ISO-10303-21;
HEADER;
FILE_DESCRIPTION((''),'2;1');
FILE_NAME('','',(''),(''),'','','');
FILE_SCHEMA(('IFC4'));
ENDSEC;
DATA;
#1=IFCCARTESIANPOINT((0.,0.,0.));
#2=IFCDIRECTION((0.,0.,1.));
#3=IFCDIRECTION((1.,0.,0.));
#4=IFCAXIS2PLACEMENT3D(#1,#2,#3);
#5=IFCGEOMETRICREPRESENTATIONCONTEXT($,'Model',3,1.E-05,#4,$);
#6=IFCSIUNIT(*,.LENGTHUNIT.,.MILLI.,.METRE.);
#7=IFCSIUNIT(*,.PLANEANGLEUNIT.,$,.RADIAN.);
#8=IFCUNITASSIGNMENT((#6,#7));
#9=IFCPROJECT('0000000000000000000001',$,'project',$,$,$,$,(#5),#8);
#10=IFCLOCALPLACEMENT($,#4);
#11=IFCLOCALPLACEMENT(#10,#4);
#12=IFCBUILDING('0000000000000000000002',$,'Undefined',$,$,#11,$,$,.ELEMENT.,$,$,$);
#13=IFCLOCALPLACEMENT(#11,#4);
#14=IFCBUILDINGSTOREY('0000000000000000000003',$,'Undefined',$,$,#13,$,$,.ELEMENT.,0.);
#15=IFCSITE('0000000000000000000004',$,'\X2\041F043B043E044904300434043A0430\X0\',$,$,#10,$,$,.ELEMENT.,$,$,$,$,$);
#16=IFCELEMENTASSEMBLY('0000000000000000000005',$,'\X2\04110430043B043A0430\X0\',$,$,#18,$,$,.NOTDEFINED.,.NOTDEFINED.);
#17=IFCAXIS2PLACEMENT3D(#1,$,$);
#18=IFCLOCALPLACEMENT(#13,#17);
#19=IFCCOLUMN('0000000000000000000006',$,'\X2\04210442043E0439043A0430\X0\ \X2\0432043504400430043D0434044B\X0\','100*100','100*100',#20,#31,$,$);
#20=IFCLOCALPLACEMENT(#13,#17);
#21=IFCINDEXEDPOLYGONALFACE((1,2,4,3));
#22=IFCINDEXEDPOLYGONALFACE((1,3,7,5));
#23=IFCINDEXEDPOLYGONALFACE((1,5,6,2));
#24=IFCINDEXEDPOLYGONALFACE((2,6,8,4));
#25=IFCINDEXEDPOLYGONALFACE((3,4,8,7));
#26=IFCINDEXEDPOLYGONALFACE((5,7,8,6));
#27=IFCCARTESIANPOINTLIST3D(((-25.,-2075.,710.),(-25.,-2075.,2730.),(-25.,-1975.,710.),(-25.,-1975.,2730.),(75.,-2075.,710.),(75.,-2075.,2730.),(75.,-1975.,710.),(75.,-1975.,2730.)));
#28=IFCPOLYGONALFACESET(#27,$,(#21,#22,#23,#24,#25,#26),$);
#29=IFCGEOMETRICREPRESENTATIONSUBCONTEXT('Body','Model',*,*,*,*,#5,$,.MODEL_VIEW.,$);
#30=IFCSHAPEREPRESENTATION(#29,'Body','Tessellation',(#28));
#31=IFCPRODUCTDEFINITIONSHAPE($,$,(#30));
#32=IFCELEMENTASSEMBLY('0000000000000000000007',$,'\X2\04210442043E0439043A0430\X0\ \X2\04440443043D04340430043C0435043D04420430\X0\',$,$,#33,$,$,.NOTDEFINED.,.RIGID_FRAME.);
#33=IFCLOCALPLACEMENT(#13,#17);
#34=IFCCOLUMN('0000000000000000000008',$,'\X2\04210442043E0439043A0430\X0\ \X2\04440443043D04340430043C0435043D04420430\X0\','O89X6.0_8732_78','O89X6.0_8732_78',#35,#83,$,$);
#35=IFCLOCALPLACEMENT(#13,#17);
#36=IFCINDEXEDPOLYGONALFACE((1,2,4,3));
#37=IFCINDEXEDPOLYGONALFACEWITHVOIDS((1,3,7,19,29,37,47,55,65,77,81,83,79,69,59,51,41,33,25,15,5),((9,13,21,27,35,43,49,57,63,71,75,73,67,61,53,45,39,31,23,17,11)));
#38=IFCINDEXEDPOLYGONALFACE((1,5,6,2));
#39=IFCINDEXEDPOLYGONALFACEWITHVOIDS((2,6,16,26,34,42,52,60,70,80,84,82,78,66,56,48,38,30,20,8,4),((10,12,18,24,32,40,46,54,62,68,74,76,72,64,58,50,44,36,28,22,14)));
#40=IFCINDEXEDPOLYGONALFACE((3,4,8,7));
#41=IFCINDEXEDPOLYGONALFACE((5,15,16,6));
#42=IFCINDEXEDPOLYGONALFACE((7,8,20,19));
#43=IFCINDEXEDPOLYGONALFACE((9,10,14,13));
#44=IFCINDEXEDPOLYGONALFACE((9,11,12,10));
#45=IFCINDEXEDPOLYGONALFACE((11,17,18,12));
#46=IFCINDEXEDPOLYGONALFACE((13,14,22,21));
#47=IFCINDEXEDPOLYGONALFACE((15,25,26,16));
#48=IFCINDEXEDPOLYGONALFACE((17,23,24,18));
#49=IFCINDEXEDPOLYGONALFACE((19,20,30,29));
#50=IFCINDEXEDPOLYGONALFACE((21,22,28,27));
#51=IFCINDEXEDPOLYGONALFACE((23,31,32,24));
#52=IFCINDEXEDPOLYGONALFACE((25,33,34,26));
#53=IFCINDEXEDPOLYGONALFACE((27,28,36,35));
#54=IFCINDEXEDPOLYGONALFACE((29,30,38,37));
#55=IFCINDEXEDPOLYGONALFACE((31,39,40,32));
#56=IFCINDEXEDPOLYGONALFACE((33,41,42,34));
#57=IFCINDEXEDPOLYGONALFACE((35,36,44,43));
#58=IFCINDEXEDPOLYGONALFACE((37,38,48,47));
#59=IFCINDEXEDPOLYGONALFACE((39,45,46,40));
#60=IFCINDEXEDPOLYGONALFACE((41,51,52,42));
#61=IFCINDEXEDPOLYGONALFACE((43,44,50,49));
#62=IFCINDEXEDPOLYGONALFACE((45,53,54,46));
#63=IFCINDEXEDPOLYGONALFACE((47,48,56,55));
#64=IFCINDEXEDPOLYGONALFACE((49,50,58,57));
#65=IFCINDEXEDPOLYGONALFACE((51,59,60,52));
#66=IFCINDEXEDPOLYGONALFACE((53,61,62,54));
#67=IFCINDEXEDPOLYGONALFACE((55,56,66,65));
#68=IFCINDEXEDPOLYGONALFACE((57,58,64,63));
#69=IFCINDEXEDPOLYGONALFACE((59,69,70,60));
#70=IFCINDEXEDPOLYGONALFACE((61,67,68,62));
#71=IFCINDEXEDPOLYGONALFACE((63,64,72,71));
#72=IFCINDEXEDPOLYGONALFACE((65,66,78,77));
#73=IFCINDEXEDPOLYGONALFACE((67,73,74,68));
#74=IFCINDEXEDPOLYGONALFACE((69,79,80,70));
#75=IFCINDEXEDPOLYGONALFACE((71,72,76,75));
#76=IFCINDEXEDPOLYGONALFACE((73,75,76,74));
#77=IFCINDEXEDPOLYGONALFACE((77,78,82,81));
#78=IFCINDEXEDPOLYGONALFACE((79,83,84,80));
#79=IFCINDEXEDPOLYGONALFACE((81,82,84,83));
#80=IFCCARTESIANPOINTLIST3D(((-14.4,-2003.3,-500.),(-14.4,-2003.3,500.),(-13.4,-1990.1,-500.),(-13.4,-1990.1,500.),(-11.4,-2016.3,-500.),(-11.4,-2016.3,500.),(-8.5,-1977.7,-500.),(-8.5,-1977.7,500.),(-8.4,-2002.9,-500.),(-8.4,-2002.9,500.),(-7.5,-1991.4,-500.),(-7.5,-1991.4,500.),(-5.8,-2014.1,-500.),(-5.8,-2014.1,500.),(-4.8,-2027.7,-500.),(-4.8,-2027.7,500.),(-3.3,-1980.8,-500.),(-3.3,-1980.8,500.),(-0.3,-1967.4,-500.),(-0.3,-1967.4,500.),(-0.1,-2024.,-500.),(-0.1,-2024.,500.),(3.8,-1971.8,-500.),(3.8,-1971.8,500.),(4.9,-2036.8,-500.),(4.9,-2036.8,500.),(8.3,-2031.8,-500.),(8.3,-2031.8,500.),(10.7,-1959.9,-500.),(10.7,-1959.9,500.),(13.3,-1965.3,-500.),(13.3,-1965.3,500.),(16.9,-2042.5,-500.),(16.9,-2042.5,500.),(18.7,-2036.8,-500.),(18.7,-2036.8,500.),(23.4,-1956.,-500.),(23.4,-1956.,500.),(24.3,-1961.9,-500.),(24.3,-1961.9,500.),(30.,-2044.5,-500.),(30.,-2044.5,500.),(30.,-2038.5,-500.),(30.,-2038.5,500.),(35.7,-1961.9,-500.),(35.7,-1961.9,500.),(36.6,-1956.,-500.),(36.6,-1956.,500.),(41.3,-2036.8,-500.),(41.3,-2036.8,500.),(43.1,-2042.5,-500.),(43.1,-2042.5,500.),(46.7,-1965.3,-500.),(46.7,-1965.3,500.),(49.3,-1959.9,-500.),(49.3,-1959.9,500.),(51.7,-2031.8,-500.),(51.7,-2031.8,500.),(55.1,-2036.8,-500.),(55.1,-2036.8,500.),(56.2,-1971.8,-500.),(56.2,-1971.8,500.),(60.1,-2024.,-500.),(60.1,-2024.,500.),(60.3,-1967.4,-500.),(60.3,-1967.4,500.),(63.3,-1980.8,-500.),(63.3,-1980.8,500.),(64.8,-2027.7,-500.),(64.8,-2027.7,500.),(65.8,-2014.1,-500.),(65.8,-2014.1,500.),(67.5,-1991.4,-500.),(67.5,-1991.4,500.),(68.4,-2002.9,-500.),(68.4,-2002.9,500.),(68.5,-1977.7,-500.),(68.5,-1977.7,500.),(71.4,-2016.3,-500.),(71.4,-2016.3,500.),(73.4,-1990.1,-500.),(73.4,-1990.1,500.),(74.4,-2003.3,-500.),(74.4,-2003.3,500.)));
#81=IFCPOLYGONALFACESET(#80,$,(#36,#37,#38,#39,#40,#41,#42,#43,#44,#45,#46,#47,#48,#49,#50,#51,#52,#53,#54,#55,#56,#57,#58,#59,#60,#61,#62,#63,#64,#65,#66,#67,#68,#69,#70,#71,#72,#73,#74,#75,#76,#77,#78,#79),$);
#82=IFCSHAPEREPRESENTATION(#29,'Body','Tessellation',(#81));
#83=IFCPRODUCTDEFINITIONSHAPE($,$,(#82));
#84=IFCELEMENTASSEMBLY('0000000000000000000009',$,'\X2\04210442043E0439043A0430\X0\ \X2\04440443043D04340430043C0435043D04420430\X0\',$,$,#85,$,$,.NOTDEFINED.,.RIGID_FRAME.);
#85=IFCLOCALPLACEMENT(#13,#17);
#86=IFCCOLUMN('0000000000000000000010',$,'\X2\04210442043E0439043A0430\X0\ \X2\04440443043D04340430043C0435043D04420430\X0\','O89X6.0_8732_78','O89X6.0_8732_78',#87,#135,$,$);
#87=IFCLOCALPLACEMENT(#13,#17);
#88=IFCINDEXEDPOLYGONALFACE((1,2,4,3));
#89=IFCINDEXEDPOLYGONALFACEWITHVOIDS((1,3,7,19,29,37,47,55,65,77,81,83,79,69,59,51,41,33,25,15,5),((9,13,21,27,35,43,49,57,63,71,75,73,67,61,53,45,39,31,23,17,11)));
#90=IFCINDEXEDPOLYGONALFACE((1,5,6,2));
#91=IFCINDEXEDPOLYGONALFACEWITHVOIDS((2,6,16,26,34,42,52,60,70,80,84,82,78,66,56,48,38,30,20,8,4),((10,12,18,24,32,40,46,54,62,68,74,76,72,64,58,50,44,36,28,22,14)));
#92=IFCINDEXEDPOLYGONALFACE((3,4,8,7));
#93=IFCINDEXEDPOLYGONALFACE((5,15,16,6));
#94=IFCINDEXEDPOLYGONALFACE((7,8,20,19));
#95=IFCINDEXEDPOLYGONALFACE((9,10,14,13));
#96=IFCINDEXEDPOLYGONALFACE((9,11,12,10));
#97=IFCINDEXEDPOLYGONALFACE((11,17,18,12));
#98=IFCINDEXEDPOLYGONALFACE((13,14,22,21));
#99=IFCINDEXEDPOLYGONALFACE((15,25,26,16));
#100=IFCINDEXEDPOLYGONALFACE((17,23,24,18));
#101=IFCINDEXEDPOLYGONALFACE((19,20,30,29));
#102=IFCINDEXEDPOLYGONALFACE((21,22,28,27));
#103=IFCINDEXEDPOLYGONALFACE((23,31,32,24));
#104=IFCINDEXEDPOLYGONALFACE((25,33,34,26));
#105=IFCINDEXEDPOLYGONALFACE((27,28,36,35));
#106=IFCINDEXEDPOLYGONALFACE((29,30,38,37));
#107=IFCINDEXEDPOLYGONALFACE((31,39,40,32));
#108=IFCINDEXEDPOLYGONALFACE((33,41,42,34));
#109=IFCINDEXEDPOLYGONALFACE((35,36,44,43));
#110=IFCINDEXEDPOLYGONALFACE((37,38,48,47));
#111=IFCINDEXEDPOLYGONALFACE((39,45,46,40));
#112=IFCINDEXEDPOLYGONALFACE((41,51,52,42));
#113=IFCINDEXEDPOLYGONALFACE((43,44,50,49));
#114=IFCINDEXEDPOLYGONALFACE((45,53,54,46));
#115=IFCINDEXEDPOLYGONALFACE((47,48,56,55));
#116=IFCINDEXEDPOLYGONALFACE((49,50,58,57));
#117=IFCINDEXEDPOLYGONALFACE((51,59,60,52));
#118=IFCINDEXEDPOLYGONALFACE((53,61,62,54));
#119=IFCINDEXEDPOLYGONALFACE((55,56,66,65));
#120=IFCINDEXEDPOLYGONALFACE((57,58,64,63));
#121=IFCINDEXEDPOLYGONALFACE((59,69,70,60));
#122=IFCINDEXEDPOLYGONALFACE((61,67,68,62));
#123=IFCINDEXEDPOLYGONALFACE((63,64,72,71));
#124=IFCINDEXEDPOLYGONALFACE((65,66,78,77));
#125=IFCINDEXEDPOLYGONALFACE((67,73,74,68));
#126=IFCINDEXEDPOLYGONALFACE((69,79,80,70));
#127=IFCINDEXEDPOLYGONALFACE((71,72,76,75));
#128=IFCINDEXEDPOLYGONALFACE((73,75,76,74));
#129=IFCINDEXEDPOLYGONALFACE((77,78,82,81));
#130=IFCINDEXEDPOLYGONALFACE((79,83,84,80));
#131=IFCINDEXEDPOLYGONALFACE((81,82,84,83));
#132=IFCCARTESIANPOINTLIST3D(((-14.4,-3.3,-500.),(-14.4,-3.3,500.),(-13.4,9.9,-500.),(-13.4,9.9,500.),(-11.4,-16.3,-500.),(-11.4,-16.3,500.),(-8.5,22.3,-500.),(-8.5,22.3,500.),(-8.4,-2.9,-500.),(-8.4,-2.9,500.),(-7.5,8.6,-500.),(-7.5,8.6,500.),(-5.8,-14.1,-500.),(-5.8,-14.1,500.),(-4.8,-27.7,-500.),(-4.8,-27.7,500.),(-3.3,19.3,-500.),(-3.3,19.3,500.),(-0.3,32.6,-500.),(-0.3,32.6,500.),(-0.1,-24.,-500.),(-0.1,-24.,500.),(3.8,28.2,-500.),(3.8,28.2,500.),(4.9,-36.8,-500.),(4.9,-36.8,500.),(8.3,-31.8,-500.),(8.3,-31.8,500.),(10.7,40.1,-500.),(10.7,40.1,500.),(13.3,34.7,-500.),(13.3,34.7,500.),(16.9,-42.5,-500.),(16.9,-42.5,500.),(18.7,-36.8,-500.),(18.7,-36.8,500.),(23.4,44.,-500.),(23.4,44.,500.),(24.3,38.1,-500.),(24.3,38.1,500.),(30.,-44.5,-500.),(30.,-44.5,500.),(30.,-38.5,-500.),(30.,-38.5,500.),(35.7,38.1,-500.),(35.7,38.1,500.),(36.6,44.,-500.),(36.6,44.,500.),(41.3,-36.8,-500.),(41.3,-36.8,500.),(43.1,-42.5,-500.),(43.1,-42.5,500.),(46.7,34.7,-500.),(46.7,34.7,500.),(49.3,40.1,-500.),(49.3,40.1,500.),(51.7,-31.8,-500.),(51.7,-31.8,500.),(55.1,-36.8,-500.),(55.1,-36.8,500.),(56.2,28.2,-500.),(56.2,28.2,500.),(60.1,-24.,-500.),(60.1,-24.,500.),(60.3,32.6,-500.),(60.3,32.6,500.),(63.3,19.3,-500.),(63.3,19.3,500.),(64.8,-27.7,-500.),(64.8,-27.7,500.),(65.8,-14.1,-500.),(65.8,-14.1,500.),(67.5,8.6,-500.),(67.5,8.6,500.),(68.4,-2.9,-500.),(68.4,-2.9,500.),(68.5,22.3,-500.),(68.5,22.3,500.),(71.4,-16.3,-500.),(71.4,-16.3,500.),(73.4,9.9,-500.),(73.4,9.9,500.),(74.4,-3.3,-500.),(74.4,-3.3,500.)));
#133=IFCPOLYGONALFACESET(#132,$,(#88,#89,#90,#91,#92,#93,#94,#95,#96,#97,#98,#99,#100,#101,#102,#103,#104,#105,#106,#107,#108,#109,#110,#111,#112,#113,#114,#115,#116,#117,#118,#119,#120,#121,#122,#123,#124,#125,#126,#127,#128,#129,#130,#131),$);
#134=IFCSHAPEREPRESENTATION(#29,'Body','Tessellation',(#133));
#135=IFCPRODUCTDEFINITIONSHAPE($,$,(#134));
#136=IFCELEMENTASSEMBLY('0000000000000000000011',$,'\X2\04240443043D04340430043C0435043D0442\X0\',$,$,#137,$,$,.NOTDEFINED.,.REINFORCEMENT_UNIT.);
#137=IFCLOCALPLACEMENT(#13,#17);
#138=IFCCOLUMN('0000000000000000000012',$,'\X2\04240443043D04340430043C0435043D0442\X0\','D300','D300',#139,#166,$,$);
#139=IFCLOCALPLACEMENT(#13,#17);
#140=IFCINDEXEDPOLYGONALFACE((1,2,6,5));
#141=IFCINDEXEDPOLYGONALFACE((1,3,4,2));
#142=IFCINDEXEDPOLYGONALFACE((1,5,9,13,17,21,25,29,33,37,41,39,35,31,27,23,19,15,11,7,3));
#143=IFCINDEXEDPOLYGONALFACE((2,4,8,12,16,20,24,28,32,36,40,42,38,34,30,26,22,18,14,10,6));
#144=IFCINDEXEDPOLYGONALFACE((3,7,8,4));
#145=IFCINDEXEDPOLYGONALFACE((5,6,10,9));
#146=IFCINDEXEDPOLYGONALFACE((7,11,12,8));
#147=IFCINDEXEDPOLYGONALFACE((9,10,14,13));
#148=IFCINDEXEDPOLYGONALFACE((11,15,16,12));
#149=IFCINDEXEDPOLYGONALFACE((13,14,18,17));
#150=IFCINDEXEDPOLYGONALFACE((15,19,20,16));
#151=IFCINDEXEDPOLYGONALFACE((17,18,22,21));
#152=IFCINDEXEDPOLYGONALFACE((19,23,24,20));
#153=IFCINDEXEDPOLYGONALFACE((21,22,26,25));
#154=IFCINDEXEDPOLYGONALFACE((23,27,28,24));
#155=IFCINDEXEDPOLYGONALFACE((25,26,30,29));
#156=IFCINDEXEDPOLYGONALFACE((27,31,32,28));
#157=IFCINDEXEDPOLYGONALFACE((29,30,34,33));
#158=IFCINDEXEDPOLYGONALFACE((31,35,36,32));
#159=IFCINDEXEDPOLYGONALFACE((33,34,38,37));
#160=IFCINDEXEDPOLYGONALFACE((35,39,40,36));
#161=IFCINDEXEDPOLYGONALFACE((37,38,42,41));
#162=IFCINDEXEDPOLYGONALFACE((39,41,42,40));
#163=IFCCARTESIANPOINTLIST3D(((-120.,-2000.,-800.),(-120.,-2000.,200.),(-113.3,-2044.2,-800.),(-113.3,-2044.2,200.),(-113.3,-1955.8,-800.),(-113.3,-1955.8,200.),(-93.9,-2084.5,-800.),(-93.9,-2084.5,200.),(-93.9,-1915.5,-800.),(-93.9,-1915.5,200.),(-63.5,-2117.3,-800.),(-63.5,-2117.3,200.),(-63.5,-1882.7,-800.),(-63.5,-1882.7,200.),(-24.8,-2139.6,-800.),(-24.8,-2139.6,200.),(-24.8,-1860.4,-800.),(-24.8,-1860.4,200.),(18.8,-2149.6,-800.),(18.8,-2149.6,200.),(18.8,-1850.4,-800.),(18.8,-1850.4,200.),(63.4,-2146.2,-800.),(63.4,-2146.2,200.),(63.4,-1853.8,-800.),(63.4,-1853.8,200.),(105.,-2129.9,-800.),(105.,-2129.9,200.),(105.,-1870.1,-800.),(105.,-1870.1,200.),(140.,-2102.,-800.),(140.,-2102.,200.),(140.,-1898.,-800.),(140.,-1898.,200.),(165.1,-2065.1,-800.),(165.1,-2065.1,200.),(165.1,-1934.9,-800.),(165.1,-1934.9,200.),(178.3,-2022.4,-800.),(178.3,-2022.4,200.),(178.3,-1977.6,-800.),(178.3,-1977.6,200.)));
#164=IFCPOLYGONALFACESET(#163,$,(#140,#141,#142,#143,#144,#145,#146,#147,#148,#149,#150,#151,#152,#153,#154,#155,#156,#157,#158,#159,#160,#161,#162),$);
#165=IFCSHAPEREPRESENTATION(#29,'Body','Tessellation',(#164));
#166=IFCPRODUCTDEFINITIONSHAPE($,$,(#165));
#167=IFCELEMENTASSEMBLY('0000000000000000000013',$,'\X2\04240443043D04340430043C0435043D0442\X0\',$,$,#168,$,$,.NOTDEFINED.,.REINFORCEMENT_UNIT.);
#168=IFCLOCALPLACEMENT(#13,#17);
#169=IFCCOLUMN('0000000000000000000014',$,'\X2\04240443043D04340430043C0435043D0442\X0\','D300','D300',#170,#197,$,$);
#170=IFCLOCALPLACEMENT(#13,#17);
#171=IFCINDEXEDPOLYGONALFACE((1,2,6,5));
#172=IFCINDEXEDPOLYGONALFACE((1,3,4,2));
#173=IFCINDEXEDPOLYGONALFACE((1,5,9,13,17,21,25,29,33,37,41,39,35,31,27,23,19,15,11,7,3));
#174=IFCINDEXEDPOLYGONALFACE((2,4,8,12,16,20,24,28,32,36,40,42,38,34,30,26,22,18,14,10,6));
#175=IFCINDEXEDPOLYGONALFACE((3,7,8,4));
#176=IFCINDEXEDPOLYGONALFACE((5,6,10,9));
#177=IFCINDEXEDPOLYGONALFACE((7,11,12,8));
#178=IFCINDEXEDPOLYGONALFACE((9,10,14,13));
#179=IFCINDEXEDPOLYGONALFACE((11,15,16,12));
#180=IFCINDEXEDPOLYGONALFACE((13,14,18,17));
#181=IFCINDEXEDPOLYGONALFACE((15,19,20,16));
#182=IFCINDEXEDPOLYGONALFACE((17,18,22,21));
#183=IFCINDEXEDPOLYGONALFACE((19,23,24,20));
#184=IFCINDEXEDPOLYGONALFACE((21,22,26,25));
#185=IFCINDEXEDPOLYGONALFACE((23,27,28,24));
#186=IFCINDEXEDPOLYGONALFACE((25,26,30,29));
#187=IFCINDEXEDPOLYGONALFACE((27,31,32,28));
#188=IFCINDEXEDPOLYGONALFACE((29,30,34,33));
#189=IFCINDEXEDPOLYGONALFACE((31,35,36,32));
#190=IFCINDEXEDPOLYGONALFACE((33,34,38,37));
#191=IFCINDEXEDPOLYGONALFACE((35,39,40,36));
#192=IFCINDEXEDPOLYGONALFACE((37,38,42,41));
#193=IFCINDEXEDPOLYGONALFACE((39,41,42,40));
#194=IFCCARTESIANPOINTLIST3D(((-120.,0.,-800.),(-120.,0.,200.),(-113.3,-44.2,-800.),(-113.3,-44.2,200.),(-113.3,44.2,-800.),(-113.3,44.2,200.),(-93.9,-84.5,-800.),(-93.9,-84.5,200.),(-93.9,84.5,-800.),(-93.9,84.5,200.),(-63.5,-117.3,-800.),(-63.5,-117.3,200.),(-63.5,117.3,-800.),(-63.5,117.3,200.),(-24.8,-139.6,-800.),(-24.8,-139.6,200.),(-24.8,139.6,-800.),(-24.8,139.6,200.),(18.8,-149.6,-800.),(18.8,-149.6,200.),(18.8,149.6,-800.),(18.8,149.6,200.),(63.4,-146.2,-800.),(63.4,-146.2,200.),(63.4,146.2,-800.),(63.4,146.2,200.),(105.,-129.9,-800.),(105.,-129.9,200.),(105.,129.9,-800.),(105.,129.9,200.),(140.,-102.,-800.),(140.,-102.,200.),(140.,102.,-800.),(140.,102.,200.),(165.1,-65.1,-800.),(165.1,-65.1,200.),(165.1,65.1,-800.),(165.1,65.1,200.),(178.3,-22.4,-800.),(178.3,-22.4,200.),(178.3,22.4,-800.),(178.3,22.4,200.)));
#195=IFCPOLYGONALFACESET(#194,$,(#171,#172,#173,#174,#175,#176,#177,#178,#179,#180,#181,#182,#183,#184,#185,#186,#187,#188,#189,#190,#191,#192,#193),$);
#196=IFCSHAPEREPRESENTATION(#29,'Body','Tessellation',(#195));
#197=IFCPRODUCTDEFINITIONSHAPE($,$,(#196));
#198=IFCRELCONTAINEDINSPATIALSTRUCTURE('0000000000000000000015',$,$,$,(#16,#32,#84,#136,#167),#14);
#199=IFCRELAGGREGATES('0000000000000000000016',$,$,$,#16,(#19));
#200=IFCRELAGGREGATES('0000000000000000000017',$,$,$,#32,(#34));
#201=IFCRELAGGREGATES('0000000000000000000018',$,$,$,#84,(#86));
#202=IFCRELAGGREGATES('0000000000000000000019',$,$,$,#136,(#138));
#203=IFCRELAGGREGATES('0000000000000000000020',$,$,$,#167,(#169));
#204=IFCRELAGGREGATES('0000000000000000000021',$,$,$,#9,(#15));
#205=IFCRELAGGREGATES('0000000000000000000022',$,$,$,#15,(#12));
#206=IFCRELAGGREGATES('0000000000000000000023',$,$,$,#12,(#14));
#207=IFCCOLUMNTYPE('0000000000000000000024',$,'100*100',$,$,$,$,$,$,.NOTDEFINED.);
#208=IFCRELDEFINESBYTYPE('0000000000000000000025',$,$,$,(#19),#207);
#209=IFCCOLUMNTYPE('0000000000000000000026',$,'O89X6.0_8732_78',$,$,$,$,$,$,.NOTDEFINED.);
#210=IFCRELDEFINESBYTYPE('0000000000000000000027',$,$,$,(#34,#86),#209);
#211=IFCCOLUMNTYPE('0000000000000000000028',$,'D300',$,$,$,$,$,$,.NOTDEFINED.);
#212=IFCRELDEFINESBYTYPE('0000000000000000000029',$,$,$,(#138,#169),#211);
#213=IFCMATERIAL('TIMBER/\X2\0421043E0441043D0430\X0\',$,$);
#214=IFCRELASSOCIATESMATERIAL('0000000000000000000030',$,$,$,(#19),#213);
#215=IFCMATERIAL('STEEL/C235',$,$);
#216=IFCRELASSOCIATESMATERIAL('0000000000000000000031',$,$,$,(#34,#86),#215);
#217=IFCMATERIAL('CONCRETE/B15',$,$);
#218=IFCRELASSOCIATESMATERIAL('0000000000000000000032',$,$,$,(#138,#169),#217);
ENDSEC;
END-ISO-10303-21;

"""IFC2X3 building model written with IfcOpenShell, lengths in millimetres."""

from ifc_helpers import new_model, si_unit, frame, origin_with_axes, origin_2d_with_axis, place, context, subcontext, project, spatial, rectangle, circle, hollow_circle, extrude, material, type_object, element, aggregate, save


model = new_model("IFC2X3")

# Units and contexts
model_context = context("Model", 3, precision=1e-05, world=origin_with_axes())
body_context = subcontext(model_context, "Body", "Model", "MODEL_VIEW")
ifc_project = project(units=[si_unit("LENGTHUNIT", "METRE", prefix="MILLI"), si_unit("PLANEANGLEUNIT", "RADIAN")], contexts=[model_context])

# Site, building, storey
site_placement = place(None, origin_with_axes())
site = spatial("IfcSite", under=ifc_project, at=site_placement, Name="Площадка", CompositionType="ELEMENT")
building_placement = place(site_placement, origin_with_axes())
building = spatial("IfcBuilding", under=site, at=building_placement, Name="Undefined", CompositionType="ELEMENT")
storey_placement = place(building_placement, origin_with_axes())
storey = spatial("IfcBuildingStorey", under=building, at=storey_placement, Name="Undefined", CompositionType="ELEMENT", Elevation=0.0)

# Element assemblies, columns
assembly_1_placement = place(storey_placement, origin_with_axes())
assembly_1 = element("IfcElementAssembly", 1, at=assembly_1_placement, inside=storey, Name="Балка", AssemblyPlace="NOTDEFINED", PredefinedType="NOTDEFINED")
ifc_material_1 = material(Name="TIMBER/Сосна")
column_type_1 = type_object("IfcColumnType", Name="100*100", PredefinedType="NOTDEFINED")
column_1_placement = place(assembly_1_placement, frame((25.0, -2025.0, 710.0), z_axis=(0.0, 0.0, 1.0), x_axis=(0.0, 1.0, 0.0)))
column_1 = element("IfcColumn", 2, at=column_1_placement, type_object=column_type_1, material=ifc_material_1, Name="Стойка веранды", Description="100*100", ObjectType="100*100", context=body_context, shape_type="SweptSolid", body=[
    extrude(rectangle(XDim=100.0, YDim=100.0, at=origin_2d_with_axis()), frame((0.0, 0.0, 2020.0), z_axis=(0.0, 0.0, -1.0), x_axis=(0.0, 1.0, 0.0)), (0.0, 0.0, 1.0), 2020.0),
])
aggregate(assembly_1, [column_1])
assembly_2_placement = place(storey_placement, origin_with_axes())
assembly_2 = element("IfcElementAssembly", 3, at=assembly_2_placement, inside=storey, Name="Стойка фундамента", AssemblyPlace="NOTDEFINED", PredefinedType="RIGID_FRAME")
ifc_material_2 = material(Name="STEEL/C235")
column_type_2 = type_object("IfcColumnType", Name="O89X6.0_8732_78", PredefinedType="NOTDEFINED")
column_2_placement = place(assembly_2_placement, frame((30.0, -2000.0, -500.0), z_axis=(0.0, 0.0, 1.0), x_axis=(-1.0, 0.0, 0.0)))
column_2 = element("IfcColumn", 4, at=column_2_placement, type_object=column_type_2, material=ifc_material_2, Name="Стойка фундамента", Description="O89X6.0_8732_78", ObjectType="O89X6.0_8732_78", context=body_context, shape_type="SweptSolid", body=[
    extrude(hollow_circle(Radius=44.5, WallThickness=6.0, at=origin_2d_with_axis()), frame((0.0, 0.0, 1000.0), z_axis=(0.0, 0.0, -1.0), x_axis=(0.0, 1.0, 0.0)), (0.0, 0.0, 1.0), 1000.0),
])
assembly_3_placement = place(storey_placement, origin_with_axes())
assembly_3 = element("IfcElementAssembly", 5, at=assembly_3_placement, inside=storey, Name="Стойка фундамента", AssemblyPlace="NOTDEFINED", PredefinedType="RIGID_FRAME")
column_3_placement = place(assembly_3_placement, frame((30.0, 0.0, -500.0), z_axis=(0.0, 0.0, 1.0), x_axis=(-1.0, 0.0, 0.0)))
column_3 = element("IfcColumn", 6, at=column_3_placement, type_object=column_type_2, material=ifc_material_2, Name="Стойка фундамента", Description="O89X6.0_8732_78", ObjectType="O89X6.0_8732_78", context=body_context, shape_type="SweptSolid", body=[
    extrude(hollow_circle(Radius=44.5, WallThickness=6.0, at=origin_2d_with_axis()), frame((0.0, 0.0, 1000.0), z_axis=(0.0, 0.0, -1.0), x_axis=(0.0, 1.0, 0.0)), (0.0, 0.0, 1.0), 1000.0),
])
assembly_4_placement = place(storey_placement, origin_with_axes())
assembly_4 = element("IfcElementAssembly", 7, at=assembly_4_placement, inside=storey, Name="Фундамент", AssemblyPlace="NOTDEFINED", PredefinedType="REINFORCEMENT_UNIT")
ifc_material_3 = material(Name="CONCRETE/B15")
column_type_3 = type_object("IfcColumnType", Name="D300", PredefinedType="NOTDEFINED")
column_4_placement = place(assembly_4_placement, frame((30.0, -2000.0, -800.0), z_axis=(0.0, 0.0, 1.0), x_axis=(0.0, 1.0, 0.0)))
column_4 = element("IfcColumn", 8, at=column_4_placement, type_object=column_type_3, material=ifc_material_3, Name="Фундамент", Description="D300", ObjectType="D300", context=body_context, shape_type="SweptSolid", body=[
    extrude(circle(Radius=150.0, at=origin_2d_with_axis()), frame((0.0, 0.0, 1000.0), z_axis=(0.0, 0.0, -1.0), x_axis=(0.0, 1.0, 0.0)), (0.0, 0.0, 1.0), 1000.0),
])
assembly_5_placement = place(storey_placement, origin_with_axes())
assembly_5 = element("IfcElementAssembly", 9, at=assembly_5_placement, inside=storey, Name="Фундамент", AssemblyPlace="NOTDEFINED", PredefinedType="REINFORCEMENT_UNIT")
column_5_placement = place(assembly_5_placement, frame((30.0, 0.0, -800.0), z_axis=(0.0, 0.0, 1.0), x_axis=(0.0, 1.0, 0.0)))
column_5 = element("IfcColumn", 10, at=column_5_placement, type_object=column_type_3, material=ifc_material_3, Name="Фундамент", Description="D300", ObjectType="D300", context=body_context, shape_type="SweptSolid", body=[
    extrude(circle(Radius=150.0, at=origin_2d_with_axis()), frame((0.0, 0.0, 1000.0), z_axis=(0.0, 0.0, -1.0), x_axis=(0.0, 1.0, 0.0)), (0.0, 0.0, 1.0), 1000.0),
])

aggregate(assembly_2, [column_2])
aggregate(assembly_3, [column_3])

aggregate(assembly_4, [column_4])

aggregate(assembly_5, [column_5])

save(model, "model.ifc")
